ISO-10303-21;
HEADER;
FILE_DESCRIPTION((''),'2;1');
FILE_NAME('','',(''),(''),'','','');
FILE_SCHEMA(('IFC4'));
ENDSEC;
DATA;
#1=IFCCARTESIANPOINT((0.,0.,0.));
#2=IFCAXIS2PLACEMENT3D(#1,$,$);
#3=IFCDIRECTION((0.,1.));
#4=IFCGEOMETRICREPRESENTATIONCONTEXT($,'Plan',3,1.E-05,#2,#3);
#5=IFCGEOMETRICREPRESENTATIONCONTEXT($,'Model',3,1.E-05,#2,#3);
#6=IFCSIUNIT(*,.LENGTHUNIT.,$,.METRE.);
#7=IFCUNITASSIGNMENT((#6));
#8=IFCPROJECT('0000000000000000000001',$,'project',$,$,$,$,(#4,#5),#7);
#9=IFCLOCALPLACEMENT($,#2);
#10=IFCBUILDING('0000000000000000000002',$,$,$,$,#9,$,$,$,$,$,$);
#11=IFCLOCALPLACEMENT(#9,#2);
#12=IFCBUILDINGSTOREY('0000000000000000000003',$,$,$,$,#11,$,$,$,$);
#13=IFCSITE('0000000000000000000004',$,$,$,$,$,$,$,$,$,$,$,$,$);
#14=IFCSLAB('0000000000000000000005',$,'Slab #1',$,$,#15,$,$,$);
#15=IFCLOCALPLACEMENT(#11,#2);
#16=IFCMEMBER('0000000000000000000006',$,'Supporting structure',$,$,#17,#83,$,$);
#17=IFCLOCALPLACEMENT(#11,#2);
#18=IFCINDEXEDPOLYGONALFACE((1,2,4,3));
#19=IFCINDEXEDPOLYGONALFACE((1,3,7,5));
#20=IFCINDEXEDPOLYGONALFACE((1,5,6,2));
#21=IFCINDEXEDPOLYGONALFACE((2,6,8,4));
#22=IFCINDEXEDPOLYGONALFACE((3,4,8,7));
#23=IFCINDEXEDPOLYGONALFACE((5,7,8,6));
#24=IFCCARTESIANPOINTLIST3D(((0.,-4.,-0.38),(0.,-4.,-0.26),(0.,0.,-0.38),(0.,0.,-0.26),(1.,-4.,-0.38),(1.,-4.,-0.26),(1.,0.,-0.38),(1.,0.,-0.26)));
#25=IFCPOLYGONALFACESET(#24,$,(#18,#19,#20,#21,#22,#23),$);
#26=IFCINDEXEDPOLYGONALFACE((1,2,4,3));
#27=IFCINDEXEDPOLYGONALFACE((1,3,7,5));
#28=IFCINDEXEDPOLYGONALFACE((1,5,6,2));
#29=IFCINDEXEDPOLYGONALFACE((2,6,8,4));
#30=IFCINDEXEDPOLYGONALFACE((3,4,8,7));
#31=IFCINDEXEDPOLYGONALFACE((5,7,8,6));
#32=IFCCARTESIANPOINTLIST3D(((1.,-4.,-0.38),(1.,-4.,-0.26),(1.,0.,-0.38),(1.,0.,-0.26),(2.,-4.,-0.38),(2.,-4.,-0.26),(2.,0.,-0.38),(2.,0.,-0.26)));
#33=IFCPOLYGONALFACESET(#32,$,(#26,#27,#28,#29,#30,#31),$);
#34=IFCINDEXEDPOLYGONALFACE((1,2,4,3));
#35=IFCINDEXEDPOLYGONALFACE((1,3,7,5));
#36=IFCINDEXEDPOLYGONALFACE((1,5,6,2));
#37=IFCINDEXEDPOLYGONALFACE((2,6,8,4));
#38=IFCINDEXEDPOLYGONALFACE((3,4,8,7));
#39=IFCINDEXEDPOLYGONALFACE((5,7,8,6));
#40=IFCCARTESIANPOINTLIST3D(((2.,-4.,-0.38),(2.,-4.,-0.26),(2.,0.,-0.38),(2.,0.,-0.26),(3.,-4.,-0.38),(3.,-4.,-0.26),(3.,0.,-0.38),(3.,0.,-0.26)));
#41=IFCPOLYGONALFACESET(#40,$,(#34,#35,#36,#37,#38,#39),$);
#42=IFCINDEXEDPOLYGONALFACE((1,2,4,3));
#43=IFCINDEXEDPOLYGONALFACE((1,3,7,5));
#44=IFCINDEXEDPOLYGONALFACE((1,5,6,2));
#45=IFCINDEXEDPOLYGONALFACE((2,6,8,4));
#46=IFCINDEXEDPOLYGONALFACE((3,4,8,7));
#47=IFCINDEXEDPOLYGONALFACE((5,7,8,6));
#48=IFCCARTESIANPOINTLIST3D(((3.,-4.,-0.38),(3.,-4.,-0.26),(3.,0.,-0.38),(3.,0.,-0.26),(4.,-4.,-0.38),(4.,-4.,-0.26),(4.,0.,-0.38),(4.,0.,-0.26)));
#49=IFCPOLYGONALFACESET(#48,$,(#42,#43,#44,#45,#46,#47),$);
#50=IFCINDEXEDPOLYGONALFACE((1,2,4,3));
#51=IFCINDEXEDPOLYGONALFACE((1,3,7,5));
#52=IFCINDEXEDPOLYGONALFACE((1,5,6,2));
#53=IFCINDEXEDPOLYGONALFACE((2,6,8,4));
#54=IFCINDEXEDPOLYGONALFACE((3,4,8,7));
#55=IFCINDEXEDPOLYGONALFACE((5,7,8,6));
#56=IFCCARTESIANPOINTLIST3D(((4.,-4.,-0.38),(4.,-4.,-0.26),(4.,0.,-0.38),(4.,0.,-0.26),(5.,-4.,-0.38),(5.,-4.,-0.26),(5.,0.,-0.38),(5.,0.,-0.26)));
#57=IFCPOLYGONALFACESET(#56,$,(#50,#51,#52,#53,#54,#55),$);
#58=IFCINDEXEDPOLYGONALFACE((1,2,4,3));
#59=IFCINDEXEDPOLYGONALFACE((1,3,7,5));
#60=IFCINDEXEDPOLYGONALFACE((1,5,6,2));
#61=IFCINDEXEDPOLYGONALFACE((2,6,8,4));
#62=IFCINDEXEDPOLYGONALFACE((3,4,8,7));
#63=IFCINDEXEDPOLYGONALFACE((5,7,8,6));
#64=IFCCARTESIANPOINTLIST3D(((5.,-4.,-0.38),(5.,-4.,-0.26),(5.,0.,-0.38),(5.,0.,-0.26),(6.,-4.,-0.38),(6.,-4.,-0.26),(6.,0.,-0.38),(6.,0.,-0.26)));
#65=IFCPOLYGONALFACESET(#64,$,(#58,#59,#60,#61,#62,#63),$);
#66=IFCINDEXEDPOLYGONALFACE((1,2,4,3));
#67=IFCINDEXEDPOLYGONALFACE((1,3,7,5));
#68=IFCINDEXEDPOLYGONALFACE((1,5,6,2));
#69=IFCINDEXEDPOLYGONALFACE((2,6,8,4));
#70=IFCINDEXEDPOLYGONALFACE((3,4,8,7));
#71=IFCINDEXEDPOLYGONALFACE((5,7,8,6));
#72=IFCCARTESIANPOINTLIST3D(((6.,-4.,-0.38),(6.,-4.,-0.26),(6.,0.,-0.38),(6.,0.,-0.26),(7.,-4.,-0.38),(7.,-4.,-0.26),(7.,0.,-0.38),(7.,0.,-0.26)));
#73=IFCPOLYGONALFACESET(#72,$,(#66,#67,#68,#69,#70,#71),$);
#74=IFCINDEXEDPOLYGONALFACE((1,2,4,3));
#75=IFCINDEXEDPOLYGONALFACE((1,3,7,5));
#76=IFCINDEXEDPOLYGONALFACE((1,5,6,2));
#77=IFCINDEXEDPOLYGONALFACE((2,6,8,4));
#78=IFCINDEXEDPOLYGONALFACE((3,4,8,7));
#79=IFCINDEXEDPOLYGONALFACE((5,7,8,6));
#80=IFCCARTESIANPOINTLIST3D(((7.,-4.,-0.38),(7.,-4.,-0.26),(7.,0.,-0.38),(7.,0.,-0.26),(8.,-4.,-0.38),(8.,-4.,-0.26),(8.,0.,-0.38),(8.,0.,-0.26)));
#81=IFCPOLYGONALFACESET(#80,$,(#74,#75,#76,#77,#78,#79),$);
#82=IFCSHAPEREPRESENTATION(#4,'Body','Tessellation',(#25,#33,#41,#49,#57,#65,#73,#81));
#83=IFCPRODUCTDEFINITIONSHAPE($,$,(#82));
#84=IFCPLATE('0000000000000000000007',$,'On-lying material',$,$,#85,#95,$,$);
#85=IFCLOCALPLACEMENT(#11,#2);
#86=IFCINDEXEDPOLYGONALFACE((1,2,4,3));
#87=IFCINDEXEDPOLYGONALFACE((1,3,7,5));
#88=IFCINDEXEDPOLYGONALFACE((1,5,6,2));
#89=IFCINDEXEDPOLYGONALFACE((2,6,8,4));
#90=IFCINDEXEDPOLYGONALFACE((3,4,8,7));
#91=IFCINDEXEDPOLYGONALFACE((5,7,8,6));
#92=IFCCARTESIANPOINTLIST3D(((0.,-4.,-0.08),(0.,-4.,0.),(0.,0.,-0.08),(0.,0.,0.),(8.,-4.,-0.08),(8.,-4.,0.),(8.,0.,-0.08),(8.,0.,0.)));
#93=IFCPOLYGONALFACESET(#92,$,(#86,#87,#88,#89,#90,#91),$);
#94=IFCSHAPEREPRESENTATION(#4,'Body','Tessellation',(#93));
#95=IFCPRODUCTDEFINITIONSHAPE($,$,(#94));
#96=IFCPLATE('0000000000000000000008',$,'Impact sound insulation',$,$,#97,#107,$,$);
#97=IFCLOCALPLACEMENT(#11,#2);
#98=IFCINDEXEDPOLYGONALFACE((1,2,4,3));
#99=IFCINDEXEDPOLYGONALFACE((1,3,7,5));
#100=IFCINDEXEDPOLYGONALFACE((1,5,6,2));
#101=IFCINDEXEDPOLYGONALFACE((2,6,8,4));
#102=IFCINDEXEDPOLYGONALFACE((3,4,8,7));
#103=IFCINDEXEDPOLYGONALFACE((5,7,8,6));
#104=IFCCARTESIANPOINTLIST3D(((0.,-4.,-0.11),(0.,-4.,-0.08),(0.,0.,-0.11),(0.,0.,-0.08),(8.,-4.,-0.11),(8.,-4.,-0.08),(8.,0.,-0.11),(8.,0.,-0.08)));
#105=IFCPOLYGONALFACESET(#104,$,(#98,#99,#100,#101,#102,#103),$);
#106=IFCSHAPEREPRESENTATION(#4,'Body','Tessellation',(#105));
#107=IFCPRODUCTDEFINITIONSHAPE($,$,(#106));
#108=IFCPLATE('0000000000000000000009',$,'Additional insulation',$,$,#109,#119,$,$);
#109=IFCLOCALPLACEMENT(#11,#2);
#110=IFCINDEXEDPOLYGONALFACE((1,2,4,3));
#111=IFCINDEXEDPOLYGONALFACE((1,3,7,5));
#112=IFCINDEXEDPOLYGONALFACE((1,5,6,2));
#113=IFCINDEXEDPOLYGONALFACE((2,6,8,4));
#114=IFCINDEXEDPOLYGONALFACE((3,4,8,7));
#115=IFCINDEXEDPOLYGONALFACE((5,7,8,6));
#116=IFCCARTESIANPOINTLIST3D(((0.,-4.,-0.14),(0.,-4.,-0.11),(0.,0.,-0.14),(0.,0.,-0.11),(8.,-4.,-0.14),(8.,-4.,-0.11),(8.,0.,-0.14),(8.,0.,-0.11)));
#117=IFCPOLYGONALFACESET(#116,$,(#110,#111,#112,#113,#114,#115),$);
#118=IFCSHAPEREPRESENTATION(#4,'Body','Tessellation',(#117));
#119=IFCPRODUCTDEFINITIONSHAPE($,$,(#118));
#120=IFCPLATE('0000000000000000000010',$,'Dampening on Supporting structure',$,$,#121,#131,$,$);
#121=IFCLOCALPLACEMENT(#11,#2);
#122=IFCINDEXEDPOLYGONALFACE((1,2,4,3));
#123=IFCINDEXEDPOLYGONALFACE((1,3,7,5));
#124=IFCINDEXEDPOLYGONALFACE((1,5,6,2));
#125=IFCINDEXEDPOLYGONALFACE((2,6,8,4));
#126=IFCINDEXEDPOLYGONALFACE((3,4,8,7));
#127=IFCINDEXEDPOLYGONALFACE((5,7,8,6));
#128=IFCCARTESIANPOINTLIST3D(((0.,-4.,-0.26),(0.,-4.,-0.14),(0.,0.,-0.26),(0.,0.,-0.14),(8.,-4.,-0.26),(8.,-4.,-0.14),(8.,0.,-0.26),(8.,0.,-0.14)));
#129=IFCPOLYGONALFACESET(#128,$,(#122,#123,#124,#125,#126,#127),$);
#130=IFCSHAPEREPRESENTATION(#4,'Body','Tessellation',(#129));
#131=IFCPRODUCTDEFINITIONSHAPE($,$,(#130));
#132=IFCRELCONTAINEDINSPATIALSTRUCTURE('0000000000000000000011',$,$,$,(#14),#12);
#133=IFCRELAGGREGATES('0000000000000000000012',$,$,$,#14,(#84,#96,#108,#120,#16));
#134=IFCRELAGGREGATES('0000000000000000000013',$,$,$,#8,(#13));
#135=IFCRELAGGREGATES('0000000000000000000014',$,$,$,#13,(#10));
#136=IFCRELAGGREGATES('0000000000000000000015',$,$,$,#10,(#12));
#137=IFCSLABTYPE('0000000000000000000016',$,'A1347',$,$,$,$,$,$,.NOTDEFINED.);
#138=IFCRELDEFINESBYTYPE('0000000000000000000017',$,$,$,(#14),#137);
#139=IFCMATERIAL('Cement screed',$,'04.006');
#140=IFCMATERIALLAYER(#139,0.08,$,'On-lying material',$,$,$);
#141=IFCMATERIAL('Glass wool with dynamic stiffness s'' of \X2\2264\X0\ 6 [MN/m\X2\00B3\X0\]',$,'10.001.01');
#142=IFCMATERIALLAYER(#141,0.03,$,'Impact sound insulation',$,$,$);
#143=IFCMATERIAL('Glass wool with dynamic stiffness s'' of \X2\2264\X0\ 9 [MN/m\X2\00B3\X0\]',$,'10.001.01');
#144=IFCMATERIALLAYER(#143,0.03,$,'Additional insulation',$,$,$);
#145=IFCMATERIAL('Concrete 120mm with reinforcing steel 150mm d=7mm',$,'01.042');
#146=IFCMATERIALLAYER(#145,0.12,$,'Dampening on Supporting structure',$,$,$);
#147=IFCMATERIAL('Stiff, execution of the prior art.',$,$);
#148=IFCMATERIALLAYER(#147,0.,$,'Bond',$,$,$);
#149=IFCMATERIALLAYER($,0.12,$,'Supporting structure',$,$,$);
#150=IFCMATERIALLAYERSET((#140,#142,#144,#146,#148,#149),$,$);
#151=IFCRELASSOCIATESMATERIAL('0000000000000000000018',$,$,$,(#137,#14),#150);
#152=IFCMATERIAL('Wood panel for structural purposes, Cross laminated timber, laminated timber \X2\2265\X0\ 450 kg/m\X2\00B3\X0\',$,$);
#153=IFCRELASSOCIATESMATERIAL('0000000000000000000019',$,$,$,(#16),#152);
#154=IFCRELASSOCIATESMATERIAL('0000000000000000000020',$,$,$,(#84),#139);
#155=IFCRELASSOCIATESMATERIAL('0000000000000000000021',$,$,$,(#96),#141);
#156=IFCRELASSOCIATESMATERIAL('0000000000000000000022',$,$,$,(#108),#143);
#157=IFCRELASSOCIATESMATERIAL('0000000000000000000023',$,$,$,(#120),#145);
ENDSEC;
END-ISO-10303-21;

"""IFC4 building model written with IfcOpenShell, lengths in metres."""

from ifc_helpers import new_model, si_unit, direction, frame, frame_2d, origin, origin_with_axes, place, context, project, spatial, rectangle, extrude, material, layer, layer_set, type_object, element, aggregate, save


model = new_model("IFC4")

# Units and contexts
plan_context = context("Plan", 3, precision=1e-05, world=origin(), true_north=direction((0.0, 1.0)))
model_context = context("Model", 3, precision=1e-05, world=origin(), true_north=direction((0.0, 1.0)))
ifc_project = project(units=[si_unit("LENGTHUNIT", "METRE")], contexts=[plan_context, model_context])

# Site, building, storey
site = spatial("IfcSite", under=ifc_project)
building_placement = place(None, origin())
building = spatial("IfcBuilding", under=site, at=building_placement)
storey_placement = place(building_placement, origin())
storey = spatial("IfcBuildingStorey", under=building, at=storey_placement)

# Slab, member, plates
ifc_material_1 = material(Name="Cement screed", Category="04.006")
ifc_layer_1 = layer(ifc_material_1, 0.08, Name="On-lying material")
ifc_material_2 = material(Name="Glass wool with dynamic stiffness s' of ≤ 6 [MN/m³]", Category="10.001.01")
ifc_layer_2 = layer(ifc_material_2, 0.03, Name="Impact sound insulation")
ifc_material_3 = material(Name="Glass wool with dynamic stiffness s' of ≤ 9 [MN/m³]", Category="10.001.01")
ifc_layer_3 = layer(ifc_material_3, 0.03, Name="Additional insulation")
ifc_material_4 = material(Name="Concrete 120mm with reinforcing steel 150mm d=7mm", Category="01.042")
ifc_layer_4 = layer(ifc_material_4, 0.12, Name="Dampening on Supporting structure")
ifc_material_5 = material(Name="Stiff, execution of the prior art.")
ifc_layer_5 = layer(ifc_material_5, 0.0, Name="Bond")
ifc_layer_6 = layer(None, 0.12, Name="Supporting structure")
ifc_layer_set = layer_set([ifc_layer_1, ifc_layer_2, ifc_layer_3, ifc_layer_4, ifc_layer_5, ifc_layer_6])
slab_type = type_object("IfcSlabType", Name="A1347", PredefinedType="NOTDEFINED", material=ifc_layer_set)
slab_placement = place(None, frame((0.0, 0.0, 0.0), z_axis=(0.0, 0.0, -1.0), x_axis=(1.0, 0.0, 0.0)))
slab = element("IfcSlab", 1, at=slab_placement, inside=storey, type_object=slab_type, material=ifc_layer_set, Name="Slab #1")
ifc_material_6 = material(Name="Wood panel for structural purposes, Cross laminated timber, laminated timber ≥ 450 kg/m³")
member_placement = place(slab_placement, origin())
member = element("IfcMember", 2, at=member_placement, material=ifc_material_6, Name="Supporting structure", context=plan_context, shape_type="SweptSolid", body=[
    extrude(rectangle(XDim=1.0, YDim=0.12, at=frame_2d((0.5, 0.06), x_axis=(1.0, 0.0))), frame((0.0, 4.0, 0.26), z_axis=(0.0, -1.0, 0.0), x_axis=(1.0, 0.0, 0.0)), (0.0, 0.0, 1.0), 4.0),
    extrude(rectangle(XDim=1.0, YDim=0.12, at=frame_2d((0.5, 0.06), x_axis=(1.0, 0.0))), frame((1.0, 4.0, 0.26), z_axis=(0.0, -1.0, 0.0), x_axis=(1.0, 0.0, 0.0)), (0.0, 0.0, 1.0), 4.0),
    extrude(rectangle(XDim=1.0, YDim=0.12, at=frame_2d((0.5, 0.06), x_axis=(1.0, 0.0))), frame((2.0, 4.0, 0.26), z_axis=(0.0, -1.0, 0.0), x_axis=(1.0, 0.0, 0.0)), (0.0, 0.0, 1.0), 4.0),
    extrude(rectangle(XDim=1.0, YDim=0.12, at=frame_2d((0.5, 0.06), x_axis=(1.0, 0.0))), frame((3.0, 4.0, 0.26), z_axis=(0.0, -1.0, 0.0), x_axis=(1.0, 0.0, 0.0)), (0.0, 0.0, 1.0), 4.0),
    extrude(rectangle(XDim=1.0, YDim=0.12, at=frame_2d((0.5, 0.06), x_axis=(1.0, 0.0))), frame((4.0, 4.0, 0.26), z_axis=(0.0, -1.0, 0.0), x_axis=(1.0, 0.0, 0.0)), (0.0, 0.0, 1.0), 4.0),
    extrude(rectangle(XDim=1.0, YDim=0.12, at=frame_2d((0.5, 0.06), x_axis=(1.0, 0.0))), frame((5.0, 4.0, 0.26), z_axis=(0.0, -1.0, 0.0), x_axis=(1.0, 0.0, 0.0)), (0.0, 0.0, 1.0), 4.0),
    extrude(rectangle(XDim=1.0, YDim=0.12, at=frame_2d((0.5, 0.06), x_axis=(1.0, 0.0))), frame((6.0, 4.0, 0.26), z_axis=(0.0, -1.0, 0.0), x_axis=(1.0, 0.0, 0.0)), (0.0, 0.0, 1.0), 4.0),
    extrude(rectangle(XDim=1.0, YDim=0.12, at=frame_2d((0.5, 0.06), x_axis=(1.0, 0.0))), frame((7.0, 4.0, 0.26), z_axis=(0.0, -1.0, 0.0), x_axis=(1.0, 0.0, 0.0)), (0.0, 0.0, 1.0), 4.0),
])
plate_1_placement = place(slab_placement, origin())
plate_1 = element("IfcPlate", 3, at=plate_1_placement, material=ifc_material_1, Name="On-lying material", context=plan_context, shape_type="SweptSolid", body=[
    extrude(rectangle(XDim=8.0, YDim=4.0, at=frame_2d((4.0, 2.0), x_axis=(1.0, 0.0))), origin_with_axes(), (0.0, 0.0, 1.0), 0.08),
])
plate_2_placement = place(slab_placement, origin())
plate_2 = element("IfcPlate", 4, at=plate_2_placement, material=ifc_material_2, Name="Impact sound insulation", context=plan_context, shape_type="SweptSolid", body=[
    extrude(rectangle(XDim=8.0, YDim=4.0, at=frame_2d((4.0, 2.0), x_axis=(1.0, 0.0))), frame((0.0, 0.0, 0.08), z_axis=(0.0, 0.0, 1.0), x_axis=(1.0, 0.0, 0.0)), (0.0, 0.0, 1.0), 0.03),
])
plate_3_placement = place(slab_placement, origin())
plate_3 = element("IfcPlate", 5, at=plate_3_placement, material=ifc_material_3, Name="Additional insulation", context=plan_context, shape_type="SweptSolid", body=[
    extrude(rectangle(XDim=8.0, YDim=4.0, at=frame_2d((4.0, 2.0), x_axis=(1.0, 0.0))), frame((0.0, 0.0, 0.11), z_axis=(0.0, 0.0, 1.0), x_axis=(1.0, 0.0, 0.0)), (0.0, 0.0, 1.0), 0.03),
])
plate_4_placement = place(slab_placement, origin())
plate_4 = element("IfcPlate", 6, at=plate_4_placement, material=ifc_material_4, Name="Dampening on Supporting structure", context=plan_context, shape_type="SweptSolid", body=[
    extrude(rectangle(XDim=8.0, YDim=4.0, at=frame_2d((4.0, 2.0), x_axis=(1.0, 0.0))), frame((0.0, 0.0, 0.14), z_axis=(0.0, 0.0, 1.0), x_axis=(1.0, 0.0, 0.0)), (0.0, 0.0, 1.0), 0.12),
])
aggregate(slab, [plate_1, plate_2, plate_3, plate_4, member])

save(model, "model.ifc")
